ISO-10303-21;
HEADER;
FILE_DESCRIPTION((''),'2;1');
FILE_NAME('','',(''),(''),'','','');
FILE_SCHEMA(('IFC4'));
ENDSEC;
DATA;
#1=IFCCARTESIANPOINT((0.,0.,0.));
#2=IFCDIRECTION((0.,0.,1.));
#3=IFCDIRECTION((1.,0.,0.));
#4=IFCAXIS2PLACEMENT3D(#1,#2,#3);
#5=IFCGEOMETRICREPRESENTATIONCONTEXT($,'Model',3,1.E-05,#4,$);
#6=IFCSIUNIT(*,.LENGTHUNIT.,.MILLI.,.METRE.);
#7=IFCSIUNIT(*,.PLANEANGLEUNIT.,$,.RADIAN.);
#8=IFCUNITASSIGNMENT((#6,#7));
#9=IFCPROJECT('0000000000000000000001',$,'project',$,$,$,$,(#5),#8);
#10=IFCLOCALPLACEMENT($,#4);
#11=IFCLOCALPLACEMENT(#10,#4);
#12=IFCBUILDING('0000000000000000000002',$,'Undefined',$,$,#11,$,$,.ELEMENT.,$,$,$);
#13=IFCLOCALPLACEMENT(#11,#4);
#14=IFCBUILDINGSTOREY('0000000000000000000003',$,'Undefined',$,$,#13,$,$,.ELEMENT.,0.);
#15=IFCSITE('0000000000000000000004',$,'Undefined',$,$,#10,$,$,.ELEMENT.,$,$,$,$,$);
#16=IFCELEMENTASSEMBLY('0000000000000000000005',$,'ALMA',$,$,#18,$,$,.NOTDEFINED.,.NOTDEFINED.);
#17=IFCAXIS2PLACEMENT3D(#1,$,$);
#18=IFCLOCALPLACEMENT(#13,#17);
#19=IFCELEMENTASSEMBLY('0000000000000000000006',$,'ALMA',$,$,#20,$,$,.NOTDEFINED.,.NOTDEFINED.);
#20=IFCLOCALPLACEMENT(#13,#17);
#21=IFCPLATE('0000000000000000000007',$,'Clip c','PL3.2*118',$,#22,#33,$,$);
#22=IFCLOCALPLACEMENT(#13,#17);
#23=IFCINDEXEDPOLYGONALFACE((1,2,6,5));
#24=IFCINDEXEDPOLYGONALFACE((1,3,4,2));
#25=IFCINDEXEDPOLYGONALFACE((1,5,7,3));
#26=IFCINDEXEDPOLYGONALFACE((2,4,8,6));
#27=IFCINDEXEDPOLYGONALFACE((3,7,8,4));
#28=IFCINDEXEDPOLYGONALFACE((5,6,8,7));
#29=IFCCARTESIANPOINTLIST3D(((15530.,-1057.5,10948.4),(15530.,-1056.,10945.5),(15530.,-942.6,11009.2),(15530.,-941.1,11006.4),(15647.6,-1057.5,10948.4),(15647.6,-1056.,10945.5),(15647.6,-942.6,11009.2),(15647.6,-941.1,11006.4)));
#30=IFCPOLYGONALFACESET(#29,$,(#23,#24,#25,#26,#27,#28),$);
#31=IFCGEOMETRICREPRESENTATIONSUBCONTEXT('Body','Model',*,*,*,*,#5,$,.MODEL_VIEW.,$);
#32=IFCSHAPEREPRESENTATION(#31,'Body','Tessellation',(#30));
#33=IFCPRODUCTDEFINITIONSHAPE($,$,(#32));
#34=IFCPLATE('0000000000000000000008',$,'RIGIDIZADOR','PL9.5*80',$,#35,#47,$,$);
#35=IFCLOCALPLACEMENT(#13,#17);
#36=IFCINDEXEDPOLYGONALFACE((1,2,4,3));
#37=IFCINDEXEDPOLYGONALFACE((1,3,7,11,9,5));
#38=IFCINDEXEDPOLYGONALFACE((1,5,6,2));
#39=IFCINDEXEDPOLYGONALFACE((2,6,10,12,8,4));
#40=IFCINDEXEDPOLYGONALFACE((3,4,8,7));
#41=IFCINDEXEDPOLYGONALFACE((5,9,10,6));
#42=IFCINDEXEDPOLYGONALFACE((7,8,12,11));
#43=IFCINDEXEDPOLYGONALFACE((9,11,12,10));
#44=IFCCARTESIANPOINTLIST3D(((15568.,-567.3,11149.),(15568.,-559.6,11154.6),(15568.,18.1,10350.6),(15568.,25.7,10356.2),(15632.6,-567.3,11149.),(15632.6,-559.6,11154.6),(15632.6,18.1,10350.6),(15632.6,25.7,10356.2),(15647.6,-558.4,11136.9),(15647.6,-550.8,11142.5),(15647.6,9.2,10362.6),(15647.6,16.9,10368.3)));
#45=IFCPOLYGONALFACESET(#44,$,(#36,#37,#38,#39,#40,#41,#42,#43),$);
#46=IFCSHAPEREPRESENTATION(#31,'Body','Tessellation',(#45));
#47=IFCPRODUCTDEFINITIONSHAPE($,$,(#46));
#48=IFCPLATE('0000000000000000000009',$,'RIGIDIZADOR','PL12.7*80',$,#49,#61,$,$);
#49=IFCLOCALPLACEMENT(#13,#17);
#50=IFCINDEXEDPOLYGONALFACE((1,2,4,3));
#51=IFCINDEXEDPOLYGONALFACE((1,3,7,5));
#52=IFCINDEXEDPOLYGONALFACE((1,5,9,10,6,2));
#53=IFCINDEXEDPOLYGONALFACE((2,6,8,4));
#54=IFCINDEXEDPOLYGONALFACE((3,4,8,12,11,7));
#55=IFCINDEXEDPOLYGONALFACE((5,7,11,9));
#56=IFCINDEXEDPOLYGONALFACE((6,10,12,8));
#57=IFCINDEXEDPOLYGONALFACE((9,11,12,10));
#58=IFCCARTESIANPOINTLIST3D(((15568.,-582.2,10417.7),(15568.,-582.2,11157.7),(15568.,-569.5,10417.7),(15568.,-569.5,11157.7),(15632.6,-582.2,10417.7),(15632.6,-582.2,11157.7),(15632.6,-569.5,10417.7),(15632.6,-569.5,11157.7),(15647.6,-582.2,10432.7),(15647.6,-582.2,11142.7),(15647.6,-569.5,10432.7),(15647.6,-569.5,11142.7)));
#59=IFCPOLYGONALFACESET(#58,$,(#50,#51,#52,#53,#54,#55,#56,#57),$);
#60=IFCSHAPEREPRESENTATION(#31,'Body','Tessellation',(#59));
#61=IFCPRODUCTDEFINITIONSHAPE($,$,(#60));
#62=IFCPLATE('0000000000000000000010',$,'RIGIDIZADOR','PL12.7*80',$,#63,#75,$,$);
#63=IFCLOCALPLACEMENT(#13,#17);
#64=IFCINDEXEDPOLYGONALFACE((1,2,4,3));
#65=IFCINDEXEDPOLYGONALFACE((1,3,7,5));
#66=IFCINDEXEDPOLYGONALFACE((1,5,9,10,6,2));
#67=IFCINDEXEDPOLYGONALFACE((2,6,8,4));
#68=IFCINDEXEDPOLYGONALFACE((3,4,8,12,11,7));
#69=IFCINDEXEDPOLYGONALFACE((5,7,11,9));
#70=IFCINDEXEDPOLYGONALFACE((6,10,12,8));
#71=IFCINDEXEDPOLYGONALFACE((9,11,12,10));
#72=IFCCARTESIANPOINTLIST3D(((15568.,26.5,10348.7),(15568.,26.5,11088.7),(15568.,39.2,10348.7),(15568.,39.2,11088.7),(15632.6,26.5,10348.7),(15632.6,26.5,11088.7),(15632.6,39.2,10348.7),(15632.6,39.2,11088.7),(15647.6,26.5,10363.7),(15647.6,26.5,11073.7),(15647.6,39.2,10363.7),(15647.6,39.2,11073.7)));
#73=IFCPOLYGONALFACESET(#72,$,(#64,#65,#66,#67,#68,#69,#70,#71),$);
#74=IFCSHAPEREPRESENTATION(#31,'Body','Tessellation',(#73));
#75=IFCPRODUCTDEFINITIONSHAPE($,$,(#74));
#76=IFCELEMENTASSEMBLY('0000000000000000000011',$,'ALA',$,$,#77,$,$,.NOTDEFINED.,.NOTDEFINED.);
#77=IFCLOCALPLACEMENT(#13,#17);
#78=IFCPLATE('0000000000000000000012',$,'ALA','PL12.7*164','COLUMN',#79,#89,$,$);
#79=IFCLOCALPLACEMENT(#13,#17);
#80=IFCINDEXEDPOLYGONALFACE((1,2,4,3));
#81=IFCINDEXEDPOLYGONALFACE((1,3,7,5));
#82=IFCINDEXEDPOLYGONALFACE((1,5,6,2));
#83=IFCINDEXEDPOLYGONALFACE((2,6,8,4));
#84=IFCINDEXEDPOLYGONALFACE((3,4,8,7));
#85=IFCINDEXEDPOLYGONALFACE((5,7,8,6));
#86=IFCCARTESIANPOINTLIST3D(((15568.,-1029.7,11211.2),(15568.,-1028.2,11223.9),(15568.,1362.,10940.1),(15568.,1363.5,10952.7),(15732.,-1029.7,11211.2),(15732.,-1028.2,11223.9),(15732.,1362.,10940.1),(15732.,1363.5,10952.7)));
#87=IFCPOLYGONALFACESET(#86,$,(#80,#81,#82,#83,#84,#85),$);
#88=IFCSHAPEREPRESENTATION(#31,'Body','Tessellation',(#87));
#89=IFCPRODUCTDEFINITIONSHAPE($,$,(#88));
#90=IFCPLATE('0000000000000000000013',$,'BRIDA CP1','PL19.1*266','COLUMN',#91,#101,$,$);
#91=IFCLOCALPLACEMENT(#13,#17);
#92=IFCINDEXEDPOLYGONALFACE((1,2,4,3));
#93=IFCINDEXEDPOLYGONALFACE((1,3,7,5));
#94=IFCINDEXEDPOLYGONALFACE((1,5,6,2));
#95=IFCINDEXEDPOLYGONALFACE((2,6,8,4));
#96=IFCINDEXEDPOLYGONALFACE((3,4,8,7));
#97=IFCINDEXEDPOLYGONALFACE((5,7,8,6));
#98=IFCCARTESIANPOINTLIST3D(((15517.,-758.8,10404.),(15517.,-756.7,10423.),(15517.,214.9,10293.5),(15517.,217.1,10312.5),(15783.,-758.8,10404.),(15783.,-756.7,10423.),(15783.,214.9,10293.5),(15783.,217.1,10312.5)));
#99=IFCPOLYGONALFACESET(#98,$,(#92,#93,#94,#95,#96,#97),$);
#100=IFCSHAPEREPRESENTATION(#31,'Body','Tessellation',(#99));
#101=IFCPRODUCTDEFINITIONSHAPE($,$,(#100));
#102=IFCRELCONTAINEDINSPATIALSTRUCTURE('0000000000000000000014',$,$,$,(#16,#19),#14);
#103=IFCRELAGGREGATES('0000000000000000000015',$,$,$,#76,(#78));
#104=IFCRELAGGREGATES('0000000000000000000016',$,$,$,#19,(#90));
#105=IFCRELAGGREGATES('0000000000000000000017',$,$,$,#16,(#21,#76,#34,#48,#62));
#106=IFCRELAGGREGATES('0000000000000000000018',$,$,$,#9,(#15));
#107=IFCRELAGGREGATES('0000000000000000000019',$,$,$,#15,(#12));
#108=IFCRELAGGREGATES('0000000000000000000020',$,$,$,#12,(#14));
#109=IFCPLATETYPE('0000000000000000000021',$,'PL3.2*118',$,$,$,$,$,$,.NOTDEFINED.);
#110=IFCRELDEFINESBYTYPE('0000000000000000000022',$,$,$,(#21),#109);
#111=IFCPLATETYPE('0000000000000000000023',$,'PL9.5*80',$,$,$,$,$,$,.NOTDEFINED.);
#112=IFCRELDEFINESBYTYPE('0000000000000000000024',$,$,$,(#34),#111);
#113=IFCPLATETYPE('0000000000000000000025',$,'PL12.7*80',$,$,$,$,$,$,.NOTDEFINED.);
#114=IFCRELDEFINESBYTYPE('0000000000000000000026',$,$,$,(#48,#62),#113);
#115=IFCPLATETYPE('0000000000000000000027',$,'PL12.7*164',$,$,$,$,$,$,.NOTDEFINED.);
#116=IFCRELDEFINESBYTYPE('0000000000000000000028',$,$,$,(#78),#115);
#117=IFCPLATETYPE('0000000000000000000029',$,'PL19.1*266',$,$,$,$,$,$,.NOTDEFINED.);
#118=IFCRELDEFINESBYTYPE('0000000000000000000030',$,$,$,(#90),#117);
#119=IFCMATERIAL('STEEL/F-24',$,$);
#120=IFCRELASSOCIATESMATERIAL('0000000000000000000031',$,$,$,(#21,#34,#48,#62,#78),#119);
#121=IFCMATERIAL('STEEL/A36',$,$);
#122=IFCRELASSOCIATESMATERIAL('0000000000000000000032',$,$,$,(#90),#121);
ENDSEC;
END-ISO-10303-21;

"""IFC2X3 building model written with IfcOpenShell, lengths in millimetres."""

from ifc_helpers import new_model, si_unit, frame, origin_with_axes, place, context, subcontext, project, spatial, polyline, outline, extrude, material, type_object, element, aggregate, save


model = new_model("IFC2X3")

# Units and contexts
model_context = context("Model", 3, precision=1e-05, world=origin_with_axes())
body_context = subcontext(model_context, "Body", "Model", "MODEL_VIEW")
ifc_project = project(units=[si_unit("LENGTHUNIT", "METRE", prefix="MILLI"), si_unit("PLANEANGLEUNIT", "RADIAN")], contexts=[model_context])

# Site, building, storey
site_placement = place(None, origin_with_axes())
site = spatial("IfcSite", under=ifc_project, at=site_placement, Name="Undefined", CompositionType="ELEMENT")
building_placement = place(site_placement, origin_with_axes())
building = spatial("IfcBuilding", under=site, at=building_placement, Name="Undefined", CompositionType="ELEMENT")
storey_placement = place(building_placement, origin_with_axes())
storey = spatial("IfcBuildingStorey", under=building, at=storey_placement, Name="Undefined", CompositionType="ELEMENT", Elevation=0.0)

# Shared definitions
ifc_material_1 = material(Name="STEEL/F-24")

# Element assemblies
assembly_1_placement = place(storey_placement, origin_with_axes())
assembly_1 = element("IfcElementAssembly", 1, at=assembly_1_placement, inside=storey, Name="ALMA", AssemblyPlace="NOTDEFINED", PredefinedType="NOTDEFINED")
assembly_2_placement = place(storey_placement, origin_with_axes())
assembly_2 = element("IfcElementAssembly", 2, at=assembly_2_placement, inside=storey, Name="ALMA", AssemblyPlace="NOTDEFINED", PredefinedType="NOTDEFINED")

# Plates
plate_type_1 = type_object("IfcPlateType", Name="PL3.2*118", PredefinedType="NOTDEFINED")
plate_1_placement = place(assembly_1_placement, frame((15647.6, -941.8, 11007.8), z_axis=(0.0, 0.467888, -0.883788), x_axis=(0.0, -0.883788, -0.467888)))
plate_1 = element("IfcPlate", 3, at=plate_1_placement, type_object=plate_type_1, material=ifc_material_1, Name="Clip c", Description="PL3.2*118", context=body_context, shape_type="SweptSolid", body=[
    extrude(outline(polyline([(0.0, 0.0), (130.0, 0.0), (130.0, 117.6), (0.0, 117.6), (0.0, 0.0)])), frame((0.0, 0.0, -1.6), z_axis=(0.0, 0.0, 1.0), x_axis=(1.0, 0.0, 0.0)), (0.0, 0.0, 1.0), 3.2),
])
plate_type_2 = type_object("IfcPlateType", Name="PL9.5*80", PredefinedType="NOTDEFINED")
plate_2_placement = place(assembly_1_placement, frame((15568.0, -563.5, 11151.8), z_axis=(0.0, -0.806474, -0.59127), x_axis=(0.0, 0.59127, -0.806474)))
plate_2 = element("IfcPlate", 4, at=plate_2_placement, type_object=plate_type_2, material=ifc_material_1, Name="RIGIDIZADOR", Description="PL9.5*80", context=body_context, shape_type="SweptSolid", body=[
    extrude(outline(polyline([(0.0, 0.0), (990.0, 0.0), (990.0, 64.6), (975.0, 79.6), (15.0, 79.6), (0.0, 64.6), (0.0, 0.0)])), frame((0.0, 0.0, -4.8), z_axis=(0.0, 0.0, 1.0), x_axis=(1.0, 0.0, 0.0)), (0.0, 0.0, 1.0), 9.5),
])
plate_type_3 = type_object("IfcPlateType", Name="PL12.7*80", PredefinedType="NOTDEFINED")
plate_3_placement = place(assembly_1_placement, frame((15568.0, -575.9, 11157.7), z_axis=(0.0, -1.0, 0.0), x_axis=(0.0, 0.0, -1.0)))
plate_3 = element("IfcPlate", 5, at=plate_3_placement, type_object=plate_type_3, material=ifc_material_1, Name="RIGIDIZADOR", Description="PL12.7*80", context=body_context, shape_type="SweptSolid", body=[
    extrude(outline(polyline([(0.0, 0.0), (740.0, 0.0), (740.0, 64.6), (725.0, 79.6), (15.0, 79.6), (0.0, 64.6), (0.0, 0.0)])), frame((0.0, 0.0, -6.3), z_axis=(0.0, 0.0, 1.0), x_axis=(1.0, 0.0, 0.0)), (0.0, 0.0, 1.0), 12.7),
])
plate_4_placement = place(assembly_1_placement, frame((15568.0, 32.9, 11088.7), z_axis=(0.0, -1.0, 0.0), x_axis=(0.0, 0.0, -1.0)))
plate_4 = element("IfcPlate", 6, at=plate_4_placement, type_object=plate_type_3, material=ifc_material_1, Name="RIGIDIZADOR", Description="PL12.7*80", context=body_context, shape_type="SweptSolid", body=[
    extrude(outline(polyline([(0.0, 0.0), (740.0, 0.0), (740.0, 64.6), (725.0, 79.6), (15.0, 79.6), (0.0, 64.6), (0.0, 0.0)])), frame((0.0, 0.0, -6.3), z_axis=(0.0, 0.0, 1.0), x_axis=(1.0, 0.0, 0.0)), (0.0, 0.0, 1.0), 12.7),
])

# Element assembly, plate
assembly_3_placement = place(assembly_1_placement, origin_with_axes())
assembly_3 = element("IfcElementAssembly", 7, at=assembly_3_placement, Name="ALA", AssemblyPlace="NOTDEFINED", PredefinedType="NOTDEFINED")
plate_type_4 = type_object("IfcPlateType", Name="PL12.7*164", PredefinedType="NOTDEFINED")
plate_5_placement = place(assembly_3_placement, frame((15650.0, -1028.9, 11217.6), z_axis=(0.0, -0.112645, -0.993635), x_axis=(0.0, 0.993635, -0.112645)))
plate_5 = element("IfcPlate", 8, at=plate_5_placement, type_object=plate_type_4, material=ifc_material_1, Name="ALA", Description="PL12.7*164", ObjectType="COLUMN", context=body_context, shape_type="SweptSolid", body=[
    extrude(outline(polyline([(0.0, -82.0), (0.0, 82.0), (2407.0, 82.0), (2407.0, -82.0), (0.0, -82.0)])), frame((0.0, 0.0, -6.3), z_axis=(0.0, 0.0, 1.0), x_axis=(1.0, 0.0, 0.0)), (0.0, 0.0, 1.0), 12.7),
])
aggregate(assembly_3, [plate_5])

# Plate
ifc_material_2 = material(Name="STEEL/A36")
plate_type_5 = type_object("IfcPlateType", Name="PL19.1*266", PredefinedType="NOTDEFINED")
plate_6_placement = place(assembly_2_placement, frame((15650.0, 216.0, 10303.0), z_axis=(0.0, -0.11276, -0.993622), x_axis=(0.0, -0.993622, 0.11276)))
plate_6 = element("IfcPlate", 9, at=plate_6_placement, type_object=plate_type_5, material=ifc_material_2, Name="BRIDA CP1", Description="PL19.1*266", ObjectType="COLUMN", context=body_context, shape_type="SweptSolid", body=[
    extrude(outline(polyline([(0.0, -133.0), (0.0, 133.0), (980.0, 133.0), (980.0, -133.0), (0.0, -133.0)])), frame((0.0, 0.0, -9.6), z_axis=(0.0, 0.0, 1.0), x_axis=(1.0, 0.0, 0.0)), (0.0, 0.0, 1.0), 19.1),
])

aggregate(assembly_2, [plate_6])
aggregate(assembly_1, [plate_1, assembly_3, plate_2, plate_3, plate_4])

save(model, "model.ifc")
